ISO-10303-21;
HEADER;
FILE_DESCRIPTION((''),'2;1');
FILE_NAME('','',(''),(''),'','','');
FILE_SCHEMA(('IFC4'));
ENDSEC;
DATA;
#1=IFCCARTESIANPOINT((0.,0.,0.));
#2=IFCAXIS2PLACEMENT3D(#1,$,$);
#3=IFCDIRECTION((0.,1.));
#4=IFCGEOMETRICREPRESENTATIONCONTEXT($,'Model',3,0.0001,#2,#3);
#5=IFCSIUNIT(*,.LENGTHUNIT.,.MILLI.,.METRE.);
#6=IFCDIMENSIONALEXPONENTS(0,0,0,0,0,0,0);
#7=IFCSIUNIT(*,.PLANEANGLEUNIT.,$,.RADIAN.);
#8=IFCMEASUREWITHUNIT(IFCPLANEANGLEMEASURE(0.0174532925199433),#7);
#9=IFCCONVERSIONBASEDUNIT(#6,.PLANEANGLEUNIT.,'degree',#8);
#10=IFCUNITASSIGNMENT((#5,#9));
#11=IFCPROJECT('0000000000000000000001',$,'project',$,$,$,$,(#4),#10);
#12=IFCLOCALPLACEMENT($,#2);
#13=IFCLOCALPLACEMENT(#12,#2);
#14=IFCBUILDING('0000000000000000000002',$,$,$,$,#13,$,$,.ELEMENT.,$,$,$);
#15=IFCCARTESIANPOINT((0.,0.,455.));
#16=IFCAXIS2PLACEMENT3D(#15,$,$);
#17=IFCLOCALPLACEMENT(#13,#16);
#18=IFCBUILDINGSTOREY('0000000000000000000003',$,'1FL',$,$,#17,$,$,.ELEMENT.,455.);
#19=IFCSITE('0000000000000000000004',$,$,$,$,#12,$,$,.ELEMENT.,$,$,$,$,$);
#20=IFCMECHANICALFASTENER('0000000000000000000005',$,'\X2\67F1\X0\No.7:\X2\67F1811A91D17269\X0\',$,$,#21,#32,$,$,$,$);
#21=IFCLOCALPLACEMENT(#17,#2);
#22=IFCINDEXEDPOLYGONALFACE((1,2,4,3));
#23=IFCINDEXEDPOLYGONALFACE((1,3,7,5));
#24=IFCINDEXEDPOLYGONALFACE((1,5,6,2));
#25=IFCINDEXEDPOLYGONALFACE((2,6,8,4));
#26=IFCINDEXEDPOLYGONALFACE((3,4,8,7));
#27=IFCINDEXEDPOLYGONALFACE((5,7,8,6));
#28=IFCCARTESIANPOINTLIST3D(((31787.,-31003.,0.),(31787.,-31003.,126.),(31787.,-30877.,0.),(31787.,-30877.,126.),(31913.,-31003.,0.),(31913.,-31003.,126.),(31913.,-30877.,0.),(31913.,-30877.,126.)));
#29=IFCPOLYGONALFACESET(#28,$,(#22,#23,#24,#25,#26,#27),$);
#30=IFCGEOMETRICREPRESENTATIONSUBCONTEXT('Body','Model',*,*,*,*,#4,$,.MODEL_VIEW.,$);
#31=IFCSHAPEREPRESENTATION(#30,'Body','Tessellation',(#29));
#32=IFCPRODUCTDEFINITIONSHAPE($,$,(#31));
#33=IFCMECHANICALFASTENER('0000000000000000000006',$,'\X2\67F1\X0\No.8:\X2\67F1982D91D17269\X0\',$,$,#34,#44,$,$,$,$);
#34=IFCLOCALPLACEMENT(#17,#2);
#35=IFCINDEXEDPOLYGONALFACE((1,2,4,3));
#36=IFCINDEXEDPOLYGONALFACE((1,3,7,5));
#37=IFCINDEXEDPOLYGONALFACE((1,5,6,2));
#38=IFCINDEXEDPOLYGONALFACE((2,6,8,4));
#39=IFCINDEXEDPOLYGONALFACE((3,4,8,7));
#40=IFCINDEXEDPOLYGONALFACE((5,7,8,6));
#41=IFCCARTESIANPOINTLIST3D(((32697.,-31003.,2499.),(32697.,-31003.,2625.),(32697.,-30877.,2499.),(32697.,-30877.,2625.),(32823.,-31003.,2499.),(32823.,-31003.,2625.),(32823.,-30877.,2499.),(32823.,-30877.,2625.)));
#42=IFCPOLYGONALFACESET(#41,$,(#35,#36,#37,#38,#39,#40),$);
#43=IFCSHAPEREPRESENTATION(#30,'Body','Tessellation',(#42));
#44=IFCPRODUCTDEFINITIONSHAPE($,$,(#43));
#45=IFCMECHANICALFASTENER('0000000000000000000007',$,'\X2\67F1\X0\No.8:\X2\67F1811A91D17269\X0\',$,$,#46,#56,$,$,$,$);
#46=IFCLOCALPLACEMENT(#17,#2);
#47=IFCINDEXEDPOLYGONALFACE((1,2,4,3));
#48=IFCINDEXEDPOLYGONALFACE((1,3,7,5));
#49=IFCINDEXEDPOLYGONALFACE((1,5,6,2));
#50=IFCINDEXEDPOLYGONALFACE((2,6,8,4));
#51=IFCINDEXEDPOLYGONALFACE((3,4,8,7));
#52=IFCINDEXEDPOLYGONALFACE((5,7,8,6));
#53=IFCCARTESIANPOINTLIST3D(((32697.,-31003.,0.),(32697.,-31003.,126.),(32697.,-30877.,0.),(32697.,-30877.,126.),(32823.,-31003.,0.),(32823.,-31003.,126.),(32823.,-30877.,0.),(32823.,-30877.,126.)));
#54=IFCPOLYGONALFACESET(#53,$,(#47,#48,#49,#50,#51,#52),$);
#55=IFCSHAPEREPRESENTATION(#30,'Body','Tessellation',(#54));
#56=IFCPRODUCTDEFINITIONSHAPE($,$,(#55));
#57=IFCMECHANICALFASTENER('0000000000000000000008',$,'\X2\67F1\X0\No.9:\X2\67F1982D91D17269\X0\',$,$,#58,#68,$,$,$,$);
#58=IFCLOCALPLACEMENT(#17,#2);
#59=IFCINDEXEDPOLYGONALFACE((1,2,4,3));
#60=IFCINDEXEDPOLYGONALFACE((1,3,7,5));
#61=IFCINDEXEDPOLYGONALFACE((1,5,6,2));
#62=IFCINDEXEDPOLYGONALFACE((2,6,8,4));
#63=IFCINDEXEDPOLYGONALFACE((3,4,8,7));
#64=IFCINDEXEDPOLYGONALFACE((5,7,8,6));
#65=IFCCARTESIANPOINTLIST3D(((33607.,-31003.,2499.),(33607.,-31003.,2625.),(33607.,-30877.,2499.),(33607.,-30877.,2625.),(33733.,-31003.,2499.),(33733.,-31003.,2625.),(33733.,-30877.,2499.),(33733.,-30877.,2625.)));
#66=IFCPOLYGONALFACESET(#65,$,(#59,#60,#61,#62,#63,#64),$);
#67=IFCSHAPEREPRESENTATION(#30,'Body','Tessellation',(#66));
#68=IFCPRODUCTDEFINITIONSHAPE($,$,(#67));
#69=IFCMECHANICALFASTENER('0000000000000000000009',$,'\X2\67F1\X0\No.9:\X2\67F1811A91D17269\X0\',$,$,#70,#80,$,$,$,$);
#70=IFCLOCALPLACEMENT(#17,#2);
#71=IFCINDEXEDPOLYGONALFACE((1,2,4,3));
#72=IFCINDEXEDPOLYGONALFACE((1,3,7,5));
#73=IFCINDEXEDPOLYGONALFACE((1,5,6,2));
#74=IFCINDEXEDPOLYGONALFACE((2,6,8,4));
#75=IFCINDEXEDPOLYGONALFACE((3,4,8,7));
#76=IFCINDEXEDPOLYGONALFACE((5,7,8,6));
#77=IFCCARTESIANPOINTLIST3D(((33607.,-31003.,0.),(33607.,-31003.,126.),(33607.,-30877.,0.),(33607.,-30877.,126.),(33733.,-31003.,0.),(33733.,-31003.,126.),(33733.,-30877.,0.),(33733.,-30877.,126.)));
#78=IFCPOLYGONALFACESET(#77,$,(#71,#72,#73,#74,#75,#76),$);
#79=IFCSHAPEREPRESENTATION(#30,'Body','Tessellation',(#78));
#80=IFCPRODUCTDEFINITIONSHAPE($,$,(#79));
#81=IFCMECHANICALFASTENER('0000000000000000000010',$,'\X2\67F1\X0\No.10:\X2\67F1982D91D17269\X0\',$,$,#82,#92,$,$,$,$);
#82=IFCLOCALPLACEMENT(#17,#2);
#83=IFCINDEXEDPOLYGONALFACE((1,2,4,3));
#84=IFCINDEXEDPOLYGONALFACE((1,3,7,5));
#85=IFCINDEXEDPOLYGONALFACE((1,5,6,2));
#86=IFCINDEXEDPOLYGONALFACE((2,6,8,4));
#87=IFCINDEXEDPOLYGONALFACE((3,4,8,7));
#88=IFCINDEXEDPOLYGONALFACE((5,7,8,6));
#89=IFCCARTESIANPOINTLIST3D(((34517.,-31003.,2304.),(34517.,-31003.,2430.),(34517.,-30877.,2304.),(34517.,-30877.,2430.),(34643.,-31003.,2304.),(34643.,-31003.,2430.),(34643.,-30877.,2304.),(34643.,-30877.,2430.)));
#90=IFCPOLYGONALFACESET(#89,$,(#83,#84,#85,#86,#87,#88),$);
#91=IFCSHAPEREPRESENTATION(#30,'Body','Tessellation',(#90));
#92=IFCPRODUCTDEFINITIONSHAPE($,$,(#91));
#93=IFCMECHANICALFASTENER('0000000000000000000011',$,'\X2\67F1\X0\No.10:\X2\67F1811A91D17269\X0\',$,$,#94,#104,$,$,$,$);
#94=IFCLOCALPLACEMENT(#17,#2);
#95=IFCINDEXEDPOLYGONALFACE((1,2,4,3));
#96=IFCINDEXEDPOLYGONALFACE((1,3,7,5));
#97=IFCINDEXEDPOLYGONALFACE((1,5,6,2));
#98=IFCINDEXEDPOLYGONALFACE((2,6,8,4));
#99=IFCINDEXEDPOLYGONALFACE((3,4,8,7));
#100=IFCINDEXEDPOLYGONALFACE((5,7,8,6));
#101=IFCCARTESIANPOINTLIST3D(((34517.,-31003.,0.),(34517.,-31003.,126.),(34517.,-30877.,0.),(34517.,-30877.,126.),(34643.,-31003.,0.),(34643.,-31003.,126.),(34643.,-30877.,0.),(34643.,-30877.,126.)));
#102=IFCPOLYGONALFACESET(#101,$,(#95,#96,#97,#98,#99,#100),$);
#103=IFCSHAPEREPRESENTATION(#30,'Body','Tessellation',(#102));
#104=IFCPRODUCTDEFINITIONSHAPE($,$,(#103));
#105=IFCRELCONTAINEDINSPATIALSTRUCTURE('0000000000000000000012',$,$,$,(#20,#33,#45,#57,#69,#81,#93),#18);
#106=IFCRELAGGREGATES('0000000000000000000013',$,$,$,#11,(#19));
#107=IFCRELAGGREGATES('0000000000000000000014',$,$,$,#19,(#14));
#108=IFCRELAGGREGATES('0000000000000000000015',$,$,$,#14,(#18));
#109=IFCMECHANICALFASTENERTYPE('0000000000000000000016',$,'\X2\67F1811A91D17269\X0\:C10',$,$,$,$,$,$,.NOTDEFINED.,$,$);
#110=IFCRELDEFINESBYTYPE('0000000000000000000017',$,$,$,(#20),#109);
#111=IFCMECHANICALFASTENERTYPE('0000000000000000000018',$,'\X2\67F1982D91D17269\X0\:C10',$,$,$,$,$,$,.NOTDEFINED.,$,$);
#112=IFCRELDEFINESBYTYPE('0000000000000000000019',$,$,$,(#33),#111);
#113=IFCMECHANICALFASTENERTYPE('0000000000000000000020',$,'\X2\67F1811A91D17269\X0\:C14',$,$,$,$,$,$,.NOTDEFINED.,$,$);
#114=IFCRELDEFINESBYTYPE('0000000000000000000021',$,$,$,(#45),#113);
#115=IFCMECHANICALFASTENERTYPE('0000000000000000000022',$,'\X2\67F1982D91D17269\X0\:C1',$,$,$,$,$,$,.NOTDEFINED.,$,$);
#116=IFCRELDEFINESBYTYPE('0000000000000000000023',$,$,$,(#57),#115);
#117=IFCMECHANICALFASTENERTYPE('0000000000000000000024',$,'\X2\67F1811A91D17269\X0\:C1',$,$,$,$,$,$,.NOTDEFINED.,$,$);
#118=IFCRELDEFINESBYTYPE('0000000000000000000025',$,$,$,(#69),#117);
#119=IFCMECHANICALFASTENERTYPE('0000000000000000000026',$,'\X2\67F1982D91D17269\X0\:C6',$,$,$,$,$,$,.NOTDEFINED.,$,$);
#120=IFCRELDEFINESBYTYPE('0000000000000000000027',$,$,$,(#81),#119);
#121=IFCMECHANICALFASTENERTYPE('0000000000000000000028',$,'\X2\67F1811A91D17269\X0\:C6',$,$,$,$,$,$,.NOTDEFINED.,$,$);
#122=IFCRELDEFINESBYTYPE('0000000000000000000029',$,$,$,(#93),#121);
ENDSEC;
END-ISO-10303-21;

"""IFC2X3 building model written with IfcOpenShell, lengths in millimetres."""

from ifc_helpers import new_model, entity, si_unit, converted_unit, direction, frame, origin, origin_with_axes, origin_2d, place, context, subcontext, project, spatial, rectangle, extrude, type_object, element, save


model = new_model("IFC2X3")

# Units and contexts
model_context = context("Model", 3, precision=0.0001, world=origin(), true_north=direction((0.0, 1.0)))
body_context = subcontext(model_context, "Body", "Model", "MODEL_VIEW")
ifc_project = project(units=[si_unit("LENGTHUNIT", "METRE", prefix="MILLI"), converted_unit("PLANEANGLEUNIT", "degree", entity("IfcPlaneAngleMeasure", 0.0174532925199433), si_unit("PLANEANGLEUNIT", "RADIAN"), dimensions=[0, 0, 0, 0, 0, 0, 0])], contexts=[model_context])

# Site, building, storey
site_placement = place(None, origin())
site = spatial("IfcSite", under=ifc_project, at=site_placement, CompositionType="ELEMENT")
building_placement = place(site_placement, origin())
building = spatial("IfcBuilding", under=site, at=building_placement, CompositionType="ELEMENT")
storey_placement = place(building_placement, frame((0.0, 0.0, 455.0)))
storey = spatial("IfcBuildingStorey", under=building, at=storey_placement, Name="1FL", CompositionType="ELEMENT", Elevation=455.0)

# Mechanical fasteners
mechanical_fastener_type_1 = type_object("IfcMechanicalFastenerType", Name="柱脚金物:C10")
mechanical_fastener_1_placement = place(storey_placement, frame((31850.0, -30940.0, 0.0)))
element("IfcMechanicalFastener", 1, at=mechanical_fastener_1_placement, inside=storey, type_object=mechanical_fastener_type_1, Name="柱No.7:柱脚金物", context=body_context, shape_type="SweptSolid", body=[
    extrude(rectangle(XDim=126.0, YDim=126.0, at=origin_2d()), origin_with_axes(), (0.0, 0.0, 1.0), 126.0),
])
mechanical_fastener_type_2 = type_object("IfcMechanicalFastenerType", Name="柱頭金物:C10")
mechanical_fastener_2_placement = place(storey_placement, frame((32760.0, -30940.0, 2499.0)))
element("IfcMechanicalFastener", 2, at=mechanical_fastener_2_placement, inside=storey, type_object=mechanical_fastener_type_2, Name="柱No.8:柱頭金物", context=body_context, shape_type="SweptSolid", body=[
    extrude(rectangle(XDim=126.0, YDim=126.0, at=origin_2d()), origin_with_axes(), (0.0, 0.0, 1.0), 126.0),
])
mechanical_fastener_type_3 = type_object("IfcMechanicalFastenerType", Name="柱脚金物:C14")
mechanical_fastener_3_placement = place(storey_placement, frame((32760.0, -30940.0, 0.0)))
element("IfcMechanicalFastener", 3, at=mechanical_fastener_3_placement, inside=storey, type_object=mechanical_fastener_type_3, Name="柱No.8:柱脚金物", context=body_context, shape_type="SweptSolid", body=[
    extrude(rectangle(XDim=126.0, YDim=126.0, at=origin_2d()), origin_with_axes(), (0.0, 0.0, 1.0), 126.0),
])
mechanical_fastener_type_4 = type_object("IfcMechanicalFastenerType", Name="柱頭金物:C1")
mechanical_fastener_4_placement = place(storey_placement, frame((33670.0, -30940.0, 2499.0)))
element("IfcMechanicalFastener", 4, at=mechanical_fastener_4_placement, inside=storey, type_object=mechanical_fastener_type_4, Name="柱No.9:柱頭金物", context=body_context, shape_type="SweptSolid", body=[
    extrude(rectangle(XDim=126.0, YDim=126.0, at=origin_2d()), origin_with_axes(), (0.0, 0.0, 1.0), 126.0),
])
mechanical_fastener_type_5 = type_object("IfcMechanicalFastenerType", Name="柱脚金物:C1")
mechanical_fastener_5_placement = place(storey_placement, frame((33670.0, -30940.0, 0.0)))
element("IfcMechanicalFastener", 5, at=mechanical_fastener_5_placement, inside=storey, type_object=mechanical_fastener_type_5, Name="柱No.9:柱脚金物", context=body_context, shape_type="SweptSolid", body=[
    extrude(rectangle(XDim=126.0, YDim=126.0, at=origin_2d()), origin_with_axes(), (0.0, 0.0, 1.0), 126.0),
])
mechanical_fastener_type_6 = type_object("IfcMechanicalFastenerType", Name="柱頭金物:C6")
mechanical_fastener_6_placement = place(storey_placement, frame((34580.0, -30940.0, 2304.0)))
element("IfcMechanicalFastener", 6, at=mechanical_fastener_6_placement, inside=storey, type_object=mechanical_fastener_type_6, Name="柱No.10:柱頭金物", context=body_context, shape_type="SweptSolid", body=[
    extrude(rectangle(XDim=126.0, YDim=126.0, at=origin_2d()), origin_with_axes(), (0.0, 0.0, 1.0), 126.0),
])
mechanical_fastener_type_7 = type_object("IfcMechanicalFastenerType", Name="柱脚金物:C6")
mechanical_fastener_7_placement = place(storey_placement, frame((34580.0, -30940.0, 0.0)))
element("IfcMechanicalFastener", 7, at=mechanical_fastener_7_placement, inside=storey, type_object=mechanical_fastener_type_7, Name="柱No.10:柱脚金物", context=body_context, shape_type="SweptSolid", body=[
    extrude(rectangle(XDim=126.0, YDim=126.0, at=origin_2d()), origin_with_axes(), (0.0, 0.0, 1.0), 126.0),
])

save(model, "model.ifc")
